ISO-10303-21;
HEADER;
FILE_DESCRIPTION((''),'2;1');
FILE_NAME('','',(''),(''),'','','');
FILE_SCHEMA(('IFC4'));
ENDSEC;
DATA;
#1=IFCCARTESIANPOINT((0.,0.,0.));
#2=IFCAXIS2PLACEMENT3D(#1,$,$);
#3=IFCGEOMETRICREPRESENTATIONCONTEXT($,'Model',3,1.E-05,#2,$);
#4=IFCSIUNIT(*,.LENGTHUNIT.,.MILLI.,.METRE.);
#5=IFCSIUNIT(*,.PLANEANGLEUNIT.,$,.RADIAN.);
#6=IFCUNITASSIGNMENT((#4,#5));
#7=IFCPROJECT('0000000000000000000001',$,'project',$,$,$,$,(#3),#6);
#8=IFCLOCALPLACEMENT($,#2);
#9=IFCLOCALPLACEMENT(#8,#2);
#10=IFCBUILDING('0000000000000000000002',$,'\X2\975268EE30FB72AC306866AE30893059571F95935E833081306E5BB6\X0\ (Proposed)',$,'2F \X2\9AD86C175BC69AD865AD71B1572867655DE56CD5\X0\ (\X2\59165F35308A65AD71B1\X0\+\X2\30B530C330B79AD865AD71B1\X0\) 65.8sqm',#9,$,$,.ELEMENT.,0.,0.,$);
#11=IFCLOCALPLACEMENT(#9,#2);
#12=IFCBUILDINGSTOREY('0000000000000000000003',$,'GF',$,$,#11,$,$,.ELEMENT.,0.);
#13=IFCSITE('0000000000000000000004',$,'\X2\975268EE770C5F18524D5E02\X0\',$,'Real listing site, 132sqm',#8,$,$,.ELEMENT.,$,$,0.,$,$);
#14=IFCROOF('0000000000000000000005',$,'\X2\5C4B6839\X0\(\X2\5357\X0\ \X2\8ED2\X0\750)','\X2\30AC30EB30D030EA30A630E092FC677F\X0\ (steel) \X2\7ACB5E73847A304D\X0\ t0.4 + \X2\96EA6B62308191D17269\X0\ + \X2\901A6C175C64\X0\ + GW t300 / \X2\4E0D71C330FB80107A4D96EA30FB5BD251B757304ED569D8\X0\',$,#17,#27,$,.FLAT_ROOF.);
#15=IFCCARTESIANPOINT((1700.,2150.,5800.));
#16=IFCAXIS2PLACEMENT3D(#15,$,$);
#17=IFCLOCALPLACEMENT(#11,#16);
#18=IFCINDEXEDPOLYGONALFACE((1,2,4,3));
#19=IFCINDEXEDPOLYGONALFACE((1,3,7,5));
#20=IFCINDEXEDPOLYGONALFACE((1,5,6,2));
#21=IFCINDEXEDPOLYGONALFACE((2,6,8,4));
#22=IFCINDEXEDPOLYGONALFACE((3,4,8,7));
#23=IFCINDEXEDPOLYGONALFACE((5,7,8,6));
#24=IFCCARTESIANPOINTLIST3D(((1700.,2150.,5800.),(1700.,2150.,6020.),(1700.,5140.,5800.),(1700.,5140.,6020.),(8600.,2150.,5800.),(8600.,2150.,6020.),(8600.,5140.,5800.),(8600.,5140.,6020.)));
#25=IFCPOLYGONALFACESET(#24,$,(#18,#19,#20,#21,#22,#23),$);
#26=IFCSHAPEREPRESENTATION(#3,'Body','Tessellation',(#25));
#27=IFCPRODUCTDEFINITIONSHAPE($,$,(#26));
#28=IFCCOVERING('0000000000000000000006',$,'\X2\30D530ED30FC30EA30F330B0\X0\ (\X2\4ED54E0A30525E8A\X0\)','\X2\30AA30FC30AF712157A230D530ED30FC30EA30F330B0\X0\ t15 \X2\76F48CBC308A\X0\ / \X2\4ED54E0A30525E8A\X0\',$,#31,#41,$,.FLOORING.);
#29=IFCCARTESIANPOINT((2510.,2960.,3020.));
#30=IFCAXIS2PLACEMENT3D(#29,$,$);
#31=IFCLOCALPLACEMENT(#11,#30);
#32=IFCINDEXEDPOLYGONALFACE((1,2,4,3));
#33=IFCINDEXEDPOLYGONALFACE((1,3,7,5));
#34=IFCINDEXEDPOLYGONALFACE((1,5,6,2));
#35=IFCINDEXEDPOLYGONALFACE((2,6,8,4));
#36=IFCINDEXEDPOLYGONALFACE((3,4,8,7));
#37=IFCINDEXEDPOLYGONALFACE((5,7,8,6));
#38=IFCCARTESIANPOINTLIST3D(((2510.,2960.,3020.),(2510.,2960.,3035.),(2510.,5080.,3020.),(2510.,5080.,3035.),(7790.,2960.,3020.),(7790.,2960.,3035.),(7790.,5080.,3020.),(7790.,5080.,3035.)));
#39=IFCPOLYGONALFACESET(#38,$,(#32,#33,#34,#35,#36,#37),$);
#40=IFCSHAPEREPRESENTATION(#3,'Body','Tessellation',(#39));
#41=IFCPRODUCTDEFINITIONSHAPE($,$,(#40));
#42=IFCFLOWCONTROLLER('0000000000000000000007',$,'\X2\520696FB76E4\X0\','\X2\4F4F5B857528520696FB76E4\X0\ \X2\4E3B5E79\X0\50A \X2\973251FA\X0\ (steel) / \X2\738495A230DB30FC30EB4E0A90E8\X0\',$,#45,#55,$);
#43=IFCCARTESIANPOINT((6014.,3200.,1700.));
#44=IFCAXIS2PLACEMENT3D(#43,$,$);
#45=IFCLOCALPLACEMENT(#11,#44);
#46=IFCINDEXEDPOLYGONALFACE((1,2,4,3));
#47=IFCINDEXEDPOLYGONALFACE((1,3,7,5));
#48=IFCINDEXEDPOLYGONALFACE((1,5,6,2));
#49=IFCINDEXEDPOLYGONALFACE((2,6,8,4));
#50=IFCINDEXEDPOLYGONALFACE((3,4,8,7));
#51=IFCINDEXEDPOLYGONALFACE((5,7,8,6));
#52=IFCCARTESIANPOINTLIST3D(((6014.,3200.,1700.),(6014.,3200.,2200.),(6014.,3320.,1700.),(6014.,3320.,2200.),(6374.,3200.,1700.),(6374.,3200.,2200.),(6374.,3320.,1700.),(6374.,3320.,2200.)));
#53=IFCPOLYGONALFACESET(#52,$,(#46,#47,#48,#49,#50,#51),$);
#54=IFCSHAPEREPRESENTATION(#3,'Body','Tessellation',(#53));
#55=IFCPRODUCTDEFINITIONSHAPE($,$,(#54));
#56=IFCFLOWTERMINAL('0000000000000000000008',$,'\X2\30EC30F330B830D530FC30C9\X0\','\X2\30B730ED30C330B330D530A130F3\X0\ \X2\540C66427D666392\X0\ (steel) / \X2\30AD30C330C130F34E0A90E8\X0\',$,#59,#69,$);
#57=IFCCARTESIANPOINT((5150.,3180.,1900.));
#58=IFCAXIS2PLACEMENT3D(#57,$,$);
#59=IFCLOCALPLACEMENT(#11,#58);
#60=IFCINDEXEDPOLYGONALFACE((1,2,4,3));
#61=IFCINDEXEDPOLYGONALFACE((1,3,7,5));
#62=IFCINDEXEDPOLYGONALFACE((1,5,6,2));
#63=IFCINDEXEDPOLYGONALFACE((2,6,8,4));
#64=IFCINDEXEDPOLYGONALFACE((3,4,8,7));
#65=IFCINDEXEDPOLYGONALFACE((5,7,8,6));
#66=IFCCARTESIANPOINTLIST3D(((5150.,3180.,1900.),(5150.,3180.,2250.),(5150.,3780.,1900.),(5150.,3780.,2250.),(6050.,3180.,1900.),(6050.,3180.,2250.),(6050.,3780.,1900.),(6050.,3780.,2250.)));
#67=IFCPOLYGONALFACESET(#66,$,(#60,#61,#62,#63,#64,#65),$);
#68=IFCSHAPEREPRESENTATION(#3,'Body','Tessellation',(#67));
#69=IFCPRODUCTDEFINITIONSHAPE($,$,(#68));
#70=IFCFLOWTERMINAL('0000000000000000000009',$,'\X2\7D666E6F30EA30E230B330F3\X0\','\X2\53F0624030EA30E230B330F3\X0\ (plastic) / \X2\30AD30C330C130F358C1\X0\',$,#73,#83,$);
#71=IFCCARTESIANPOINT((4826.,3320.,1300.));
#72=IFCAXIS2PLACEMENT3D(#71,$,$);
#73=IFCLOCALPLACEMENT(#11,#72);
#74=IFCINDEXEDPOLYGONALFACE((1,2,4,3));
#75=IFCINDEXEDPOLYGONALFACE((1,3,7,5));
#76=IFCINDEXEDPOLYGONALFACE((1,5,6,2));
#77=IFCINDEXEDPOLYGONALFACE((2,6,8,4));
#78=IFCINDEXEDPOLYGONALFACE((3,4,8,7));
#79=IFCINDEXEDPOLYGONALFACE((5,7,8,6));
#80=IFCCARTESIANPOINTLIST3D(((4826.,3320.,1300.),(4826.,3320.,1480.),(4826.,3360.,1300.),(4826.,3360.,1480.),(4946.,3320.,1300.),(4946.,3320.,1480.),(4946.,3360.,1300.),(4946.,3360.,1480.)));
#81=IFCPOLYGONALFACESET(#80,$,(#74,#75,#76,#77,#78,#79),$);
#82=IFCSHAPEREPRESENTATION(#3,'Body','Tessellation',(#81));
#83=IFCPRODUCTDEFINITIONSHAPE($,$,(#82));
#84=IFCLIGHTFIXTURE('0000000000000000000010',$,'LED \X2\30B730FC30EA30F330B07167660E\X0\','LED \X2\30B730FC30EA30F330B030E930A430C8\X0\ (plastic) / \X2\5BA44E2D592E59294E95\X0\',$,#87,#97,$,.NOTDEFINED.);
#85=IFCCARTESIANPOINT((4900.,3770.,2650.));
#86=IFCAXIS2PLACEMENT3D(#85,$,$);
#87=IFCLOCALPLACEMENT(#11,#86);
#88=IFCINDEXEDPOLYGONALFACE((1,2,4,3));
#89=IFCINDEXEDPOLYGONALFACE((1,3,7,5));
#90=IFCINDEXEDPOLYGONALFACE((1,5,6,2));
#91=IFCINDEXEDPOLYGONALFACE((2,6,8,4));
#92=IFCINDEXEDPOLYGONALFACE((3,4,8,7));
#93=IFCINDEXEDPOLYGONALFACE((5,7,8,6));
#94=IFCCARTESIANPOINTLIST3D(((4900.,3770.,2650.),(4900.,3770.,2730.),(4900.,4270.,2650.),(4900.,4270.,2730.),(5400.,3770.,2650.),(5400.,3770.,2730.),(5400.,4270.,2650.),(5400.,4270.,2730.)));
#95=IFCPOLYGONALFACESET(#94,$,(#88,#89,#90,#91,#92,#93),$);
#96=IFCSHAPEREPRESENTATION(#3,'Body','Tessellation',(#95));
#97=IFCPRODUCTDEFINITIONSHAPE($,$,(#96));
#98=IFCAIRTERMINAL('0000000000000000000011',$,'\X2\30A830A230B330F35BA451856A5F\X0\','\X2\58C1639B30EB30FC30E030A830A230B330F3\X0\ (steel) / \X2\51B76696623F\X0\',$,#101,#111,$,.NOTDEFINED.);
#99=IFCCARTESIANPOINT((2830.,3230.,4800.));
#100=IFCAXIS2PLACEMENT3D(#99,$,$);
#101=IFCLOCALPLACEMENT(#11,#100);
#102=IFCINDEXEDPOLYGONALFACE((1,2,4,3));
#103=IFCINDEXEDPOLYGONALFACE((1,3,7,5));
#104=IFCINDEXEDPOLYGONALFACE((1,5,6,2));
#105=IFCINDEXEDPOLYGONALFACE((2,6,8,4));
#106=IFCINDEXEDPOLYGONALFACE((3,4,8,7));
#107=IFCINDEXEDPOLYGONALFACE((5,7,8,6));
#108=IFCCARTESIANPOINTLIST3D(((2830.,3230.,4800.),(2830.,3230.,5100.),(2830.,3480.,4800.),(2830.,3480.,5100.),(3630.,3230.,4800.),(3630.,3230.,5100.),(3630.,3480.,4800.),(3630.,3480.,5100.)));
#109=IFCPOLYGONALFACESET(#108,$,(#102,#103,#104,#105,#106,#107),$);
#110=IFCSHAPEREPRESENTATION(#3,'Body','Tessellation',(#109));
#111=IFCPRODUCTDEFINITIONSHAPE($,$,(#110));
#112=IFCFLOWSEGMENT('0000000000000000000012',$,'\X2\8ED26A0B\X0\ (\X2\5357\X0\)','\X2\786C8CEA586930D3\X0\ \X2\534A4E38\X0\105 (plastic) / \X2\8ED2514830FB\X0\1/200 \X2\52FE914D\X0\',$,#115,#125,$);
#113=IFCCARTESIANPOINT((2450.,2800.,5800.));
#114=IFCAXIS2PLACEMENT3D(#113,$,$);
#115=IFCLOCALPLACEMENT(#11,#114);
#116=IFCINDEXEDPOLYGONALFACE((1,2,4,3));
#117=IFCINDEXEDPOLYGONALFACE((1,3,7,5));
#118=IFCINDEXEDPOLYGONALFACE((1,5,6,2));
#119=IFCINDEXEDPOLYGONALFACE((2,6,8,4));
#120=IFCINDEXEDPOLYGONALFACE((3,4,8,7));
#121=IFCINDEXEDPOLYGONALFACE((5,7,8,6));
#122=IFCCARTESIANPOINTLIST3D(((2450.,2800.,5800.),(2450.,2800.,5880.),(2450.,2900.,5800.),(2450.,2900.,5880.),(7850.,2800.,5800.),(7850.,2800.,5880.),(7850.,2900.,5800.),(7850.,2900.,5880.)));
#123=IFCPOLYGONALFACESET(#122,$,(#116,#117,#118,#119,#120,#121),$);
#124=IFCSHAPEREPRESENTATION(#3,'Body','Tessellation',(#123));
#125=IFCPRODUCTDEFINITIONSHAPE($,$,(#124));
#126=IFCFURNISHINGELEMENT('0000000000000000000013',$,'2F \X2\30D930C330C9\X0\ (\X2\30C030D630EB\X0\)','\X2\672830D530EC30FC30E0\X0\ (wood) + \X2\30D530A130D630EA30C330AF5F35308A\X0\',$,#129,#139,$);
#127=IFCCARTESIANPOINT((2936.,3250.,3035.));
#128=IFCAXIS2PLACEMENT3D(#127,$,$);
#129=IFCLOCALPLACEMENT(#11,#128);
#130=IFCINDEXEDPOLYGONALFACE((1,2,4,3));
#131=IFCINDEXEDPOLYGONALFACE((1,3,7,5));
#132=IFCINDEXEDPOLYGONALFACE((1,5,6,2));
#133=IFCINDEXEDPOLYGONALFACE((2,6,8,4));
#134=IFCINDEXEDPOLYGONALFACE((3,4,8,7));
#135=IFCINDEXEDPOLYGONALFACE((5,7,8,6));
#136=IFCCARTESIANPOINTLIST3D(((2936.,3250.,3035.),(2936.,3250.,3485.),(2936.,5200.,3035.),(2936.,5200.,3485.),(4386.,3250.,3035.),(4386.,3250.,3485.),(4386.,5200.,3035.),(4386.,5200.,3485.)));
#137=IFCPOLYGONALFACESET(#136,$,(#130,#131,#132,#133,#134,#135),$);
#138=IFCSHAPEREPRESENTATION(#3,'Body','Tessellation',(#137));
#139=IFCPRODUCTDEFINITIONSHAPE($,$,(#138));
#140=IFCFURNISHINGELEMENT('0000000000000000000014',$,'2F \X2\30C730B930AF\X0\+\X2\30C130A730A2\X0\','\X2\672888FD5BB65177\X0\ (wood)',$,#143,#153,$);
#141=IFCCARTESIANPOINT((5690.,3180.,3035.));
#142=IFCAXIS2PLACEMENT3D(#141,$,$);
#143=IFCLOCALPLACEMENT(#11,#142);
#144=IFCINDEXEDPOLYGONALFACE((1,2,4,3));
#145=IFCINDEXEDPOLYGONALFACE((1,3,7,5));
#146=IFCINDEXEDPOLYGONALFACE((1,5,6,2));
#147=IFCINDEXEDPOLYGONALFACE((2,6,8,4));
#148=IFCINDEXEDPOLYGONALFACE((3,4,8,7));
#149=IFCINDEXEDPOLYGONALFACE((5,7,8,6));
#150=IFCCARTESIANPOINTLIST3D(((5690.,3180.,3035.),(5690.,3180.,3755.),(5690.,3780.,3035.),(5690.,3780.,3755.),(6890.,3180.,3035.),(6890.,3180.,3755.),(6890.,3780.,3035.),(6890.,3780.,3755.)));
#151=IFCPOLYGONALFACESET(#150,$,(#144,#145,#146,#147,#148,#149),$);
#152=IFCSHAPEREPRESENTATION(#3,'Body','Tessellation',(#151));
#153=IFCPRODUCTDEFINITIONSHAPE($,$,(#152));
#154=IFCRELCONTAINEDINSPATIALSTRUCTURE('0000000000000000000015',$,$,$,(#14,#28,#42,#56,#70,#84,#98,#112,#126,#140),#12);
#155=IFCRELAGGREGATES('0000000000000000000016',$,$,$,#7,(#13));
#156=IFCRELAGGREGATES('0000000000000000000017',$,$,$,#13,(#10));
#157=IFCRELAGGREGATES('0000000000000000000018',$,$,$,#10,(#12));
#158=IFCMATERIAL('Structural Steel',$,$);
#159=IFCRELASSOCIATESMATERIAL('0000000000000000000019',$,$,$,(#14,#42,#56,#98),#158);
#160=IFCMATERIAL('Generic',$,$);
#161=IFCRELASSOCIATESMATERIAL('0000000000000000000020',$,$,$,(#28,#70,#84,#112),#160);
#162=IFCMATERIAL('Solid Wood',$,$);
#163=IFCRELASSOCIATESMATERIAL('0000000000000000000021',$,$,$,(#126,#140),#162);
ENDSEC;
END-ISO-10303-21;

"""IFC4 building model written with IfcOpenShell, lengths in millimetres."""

from ifc_helpers import new_model, si_unit, frame, frame_2d, origin, place, context, project, spatial, rectangle, extrude, material, element, save


model = new_model("IFC4")

# Units and contexts
model_context = context("Model", 3, precision=1e-05, world=origin())
ifc_project = project(units=[si_unit("LENGTHUNIT", "METRE", prefix="MILLI"), si_unit("PLANEANGLEUNIT", "RADIAN")], contexts=[model_context])

# Site, building, storey
site_placement = place(None, origin())
site = spatial("IfcSite", under=ifc_project, at=site_placement, Name="青森県弘前市", ObjectType="Real listing site, 132sqm", CompositionType="ELEMENT", RefElevation=0.0)
building_placement = place(site_placement, origin())
building = spatial("IfcBuilding", under=site, at=building_placement, Name="青森・犬と暮らす土間広めの家 (Proposed)", ObjectType="2F 高気密高断熱在来工法 (外張り断熱+サッシ高断熱) 65.8sqm", CompositionType="ELEMENT", ElevationOfRefHeight=0.0, ElevationOfTerrain=0.0)
storey_placement = place(building_placement, origin())
storey = spatial("IfcBuildingStorey", under=building, at=storey_placement, Name="GF", CompositionType="ELEMENT", Elevation=0.0)

# Shared definitions
ifc_material_1 = material(Name="Solid Wood")

# Roof
ifc_material_2 = material(Name="Structural Steel")
for number, where, name in (
    (1, (1700.0, 2150.0, 5800.0), "屋根(南 軒750)"),
):
    element("IfcRoof", number, at=place(storey_placement, frame(where)), inside=storey, material=ifc_material_2, Name=name, Description="ガルバリウム鋼板 (steel) 立平葺き t0.4 + 雪止め金物 + 通気層 + GW t300 / 不燃・耐積雪・寒冷地仕様", PredefinedType="FLAT_ROOF", context=model_context, shape_type="SweptSolid", body=[
        extrude(rectangle(XDim=6900.0, YDim=2990.0, at=frame_2d((3450.0, 1495.0))), frame((1700.0, 2150.0, 5800.0)), (0.0, 0.0, 1.0), 220.0),
    ])

# Covering
ifc_material_3 = material(Name="Generic")
covering_placement = place(storey_placement, frame((2510.0, 2960.0, 3020.0)))
element("IfcCovering", 2, at=covering_placement, inside=storey, material=ifc_material_3, Name="フローリング (仕上げ床)", Description="オーク無垢フローリング t15 直貼り / 仕上げ床", PredefinedType="FLOORING", context=model_context, shape_type="SweptSolid", body=[
    extrude(rectangle(XDim=5280.0, YDim=2120.0, at=frame_2d((2640.0, 1060.0))), frame((2510.0, 2960.0, 3020.0)), (0.0, 0.0, 1.0), 15.0),
])

# Flow controller
flow_controller_placement = place(storey_placement, frame((6014.0, 3200.0, 1700.0)))
element("IfcFlowController", 3, at=flow_controller_placement, inside=storey, material=ifc_material_2, Name="分電盤", Description="住宅用分電盤 主幹50A 露出 (steel) / 玄関ホール上部", context=model_context, shape_type="SweptSolid", body=[
    extrude(rectangle(XDim=360.0, YDim=120.0, at=frame_2d((180.0, 60.0))), frame((6014.0, 3200.0, 1700.0)), (0.0, 0.0, 1.0), 500.0),
])

# Flow terminals
flow_terminal_1_placement = place(storey_placement, frame((5150.0, 3180.0, 1900.0)))
element("IfcFlowTerminal", 4, at=flow_terminal_1_placement, inside=storey, material=ifc_material_2, Name="レンジフード", Description="シロッコファン 同時給排 (steel) / キッチン上部", context=model_context, shape_type="SweptSolid", body=[
    extrude(rectangle(XDim=900.0, YDim=600.0, at=frame_2d((450.0, 300.0))), frame((5150.0, 3180.0, 1900.0)), (0.0, 0.0, 1.0), 350.0),
])
flow_terminal_2_placement = place(storey_placement, frame((4826.0, 3320.0, 1300.0)))
element("IfcFlowTerminal", 5, at=flow_terminal_2_placement, inside=storey, material=ifc_material_3, Name="給湯リモコン", Description="台所リモコン (plastic) / キッチン壁", context=model_context, shape_type="SweptSolid", body=[
    extrude(rectangle(XDim=120.0, YDim=40.0, at=frame_2d((60.0, 20.0))), frame((4826.0, 3320.0, 1300.0)), (0.0, 0.0, 1.0), 180.0),
])

# Light fixture
light_fixture_placement = place(storey_placement, frame((4900.0, 3770.0, 2650.0)))
element("IfcLightFixture", 6, at=light_fixture_placement, inside=storey, material=ifc_material_3, Name="LED シーリング照明", Description="LED シーリングライト (plastic) / 室中央天井", PredefinedType="NOTDEFINED", context=model_context, shape_type="SweptSolid", body=[
    extrude(rectangle(XDim=500.0, YDim=500.0, at=frame_2d((250.0, 250.0))), frame((4900.0, 3770.0, 2650.0)), (0.0, 0.0, 1.0), 80.0),
])

# Air terminal
air_terminal_placement = place(storey_placement, frame((2830.0, 3230.0, 4800.0)))
element("IfcAirTerminal", 7, at=air_terminal_placement, inside=storey, material=ifc_material_2, Name="エアコン室内機", Description="壁掛ルームエアコン (steel) / 冷暖房", PredefinedType="NOTDEFINED", context=model_context, shape_type="SweptSolid", body=[
    extrude(rectangle(XDim=800.0, YDim=250.0, at=frame_2d((400.0, 125.0))), frame((2830.0, 3230.0, 4800.0)), (0.0, 0.0, 1.0), 300.0),
])

# Flow segment
flow_segment_placement = place(storey_placement, frame((2450.0, 2800.0, 5800.0)))
element("IfcFlowSegment", 8, at=flow_segment_placement, inside=storey, material=ifc_material_3, Name="軒樋 (南)", Description="硬質塩ビ 半丸105 (plastic) / 軒先・1/200 勾配", context=model_context, shape_type="SweptSolid", body=[
    extrude(rectangle(XDim=5400.0, YDim=100.0, at=frame_2d((2700.0, 50.0))), frame((2450.0, 2800.0, 5800.0)), (0.0, 0.0, 1.0), 80.0),
])

# Furnishing elements
furnishing_1_placement = place(storey_placement, frame((2936.0, 3250.0, 3035.0)))
element("IfcFurnishingElement", 9, at=furnishing_1_placement, inside=storey, material=ifc_material_1, Name="2F ベッド (ダブル)", Description="木フレーム (wood) + ファブリック張り", context=model_context, shape_type="SweptSolid", body=[
    extrude(rectangle(XDim=1450.0, YDim=1950.0, at=frame_2d((725.0, 975.0))), frame((2936.0, 3250.0, 3035.0)), (0.0, 0.0, 1.0), 450.0),
])
furnishing_2_placement = place(storey_placement, frame((5690.0, 3180.0, 3035.0)))
element("IfcFurnishingElement", 10, at=furnishing_2_placement, inside=storey, material=ifc_material_1, Name="2F デスク+チェア", Description="木製家具 (wood)", context=model_context, shape_type="SweptSolid", body=[
    extrude(rectangle(XDim=1200.0, YDim=600.0, at=frame_2d((600.0, 300.0))), frame((5690.0, 3180.0, 3035.0)), (0.0, 0.0, 1.0), 720.0),
])

save(model, "model.ifc")
